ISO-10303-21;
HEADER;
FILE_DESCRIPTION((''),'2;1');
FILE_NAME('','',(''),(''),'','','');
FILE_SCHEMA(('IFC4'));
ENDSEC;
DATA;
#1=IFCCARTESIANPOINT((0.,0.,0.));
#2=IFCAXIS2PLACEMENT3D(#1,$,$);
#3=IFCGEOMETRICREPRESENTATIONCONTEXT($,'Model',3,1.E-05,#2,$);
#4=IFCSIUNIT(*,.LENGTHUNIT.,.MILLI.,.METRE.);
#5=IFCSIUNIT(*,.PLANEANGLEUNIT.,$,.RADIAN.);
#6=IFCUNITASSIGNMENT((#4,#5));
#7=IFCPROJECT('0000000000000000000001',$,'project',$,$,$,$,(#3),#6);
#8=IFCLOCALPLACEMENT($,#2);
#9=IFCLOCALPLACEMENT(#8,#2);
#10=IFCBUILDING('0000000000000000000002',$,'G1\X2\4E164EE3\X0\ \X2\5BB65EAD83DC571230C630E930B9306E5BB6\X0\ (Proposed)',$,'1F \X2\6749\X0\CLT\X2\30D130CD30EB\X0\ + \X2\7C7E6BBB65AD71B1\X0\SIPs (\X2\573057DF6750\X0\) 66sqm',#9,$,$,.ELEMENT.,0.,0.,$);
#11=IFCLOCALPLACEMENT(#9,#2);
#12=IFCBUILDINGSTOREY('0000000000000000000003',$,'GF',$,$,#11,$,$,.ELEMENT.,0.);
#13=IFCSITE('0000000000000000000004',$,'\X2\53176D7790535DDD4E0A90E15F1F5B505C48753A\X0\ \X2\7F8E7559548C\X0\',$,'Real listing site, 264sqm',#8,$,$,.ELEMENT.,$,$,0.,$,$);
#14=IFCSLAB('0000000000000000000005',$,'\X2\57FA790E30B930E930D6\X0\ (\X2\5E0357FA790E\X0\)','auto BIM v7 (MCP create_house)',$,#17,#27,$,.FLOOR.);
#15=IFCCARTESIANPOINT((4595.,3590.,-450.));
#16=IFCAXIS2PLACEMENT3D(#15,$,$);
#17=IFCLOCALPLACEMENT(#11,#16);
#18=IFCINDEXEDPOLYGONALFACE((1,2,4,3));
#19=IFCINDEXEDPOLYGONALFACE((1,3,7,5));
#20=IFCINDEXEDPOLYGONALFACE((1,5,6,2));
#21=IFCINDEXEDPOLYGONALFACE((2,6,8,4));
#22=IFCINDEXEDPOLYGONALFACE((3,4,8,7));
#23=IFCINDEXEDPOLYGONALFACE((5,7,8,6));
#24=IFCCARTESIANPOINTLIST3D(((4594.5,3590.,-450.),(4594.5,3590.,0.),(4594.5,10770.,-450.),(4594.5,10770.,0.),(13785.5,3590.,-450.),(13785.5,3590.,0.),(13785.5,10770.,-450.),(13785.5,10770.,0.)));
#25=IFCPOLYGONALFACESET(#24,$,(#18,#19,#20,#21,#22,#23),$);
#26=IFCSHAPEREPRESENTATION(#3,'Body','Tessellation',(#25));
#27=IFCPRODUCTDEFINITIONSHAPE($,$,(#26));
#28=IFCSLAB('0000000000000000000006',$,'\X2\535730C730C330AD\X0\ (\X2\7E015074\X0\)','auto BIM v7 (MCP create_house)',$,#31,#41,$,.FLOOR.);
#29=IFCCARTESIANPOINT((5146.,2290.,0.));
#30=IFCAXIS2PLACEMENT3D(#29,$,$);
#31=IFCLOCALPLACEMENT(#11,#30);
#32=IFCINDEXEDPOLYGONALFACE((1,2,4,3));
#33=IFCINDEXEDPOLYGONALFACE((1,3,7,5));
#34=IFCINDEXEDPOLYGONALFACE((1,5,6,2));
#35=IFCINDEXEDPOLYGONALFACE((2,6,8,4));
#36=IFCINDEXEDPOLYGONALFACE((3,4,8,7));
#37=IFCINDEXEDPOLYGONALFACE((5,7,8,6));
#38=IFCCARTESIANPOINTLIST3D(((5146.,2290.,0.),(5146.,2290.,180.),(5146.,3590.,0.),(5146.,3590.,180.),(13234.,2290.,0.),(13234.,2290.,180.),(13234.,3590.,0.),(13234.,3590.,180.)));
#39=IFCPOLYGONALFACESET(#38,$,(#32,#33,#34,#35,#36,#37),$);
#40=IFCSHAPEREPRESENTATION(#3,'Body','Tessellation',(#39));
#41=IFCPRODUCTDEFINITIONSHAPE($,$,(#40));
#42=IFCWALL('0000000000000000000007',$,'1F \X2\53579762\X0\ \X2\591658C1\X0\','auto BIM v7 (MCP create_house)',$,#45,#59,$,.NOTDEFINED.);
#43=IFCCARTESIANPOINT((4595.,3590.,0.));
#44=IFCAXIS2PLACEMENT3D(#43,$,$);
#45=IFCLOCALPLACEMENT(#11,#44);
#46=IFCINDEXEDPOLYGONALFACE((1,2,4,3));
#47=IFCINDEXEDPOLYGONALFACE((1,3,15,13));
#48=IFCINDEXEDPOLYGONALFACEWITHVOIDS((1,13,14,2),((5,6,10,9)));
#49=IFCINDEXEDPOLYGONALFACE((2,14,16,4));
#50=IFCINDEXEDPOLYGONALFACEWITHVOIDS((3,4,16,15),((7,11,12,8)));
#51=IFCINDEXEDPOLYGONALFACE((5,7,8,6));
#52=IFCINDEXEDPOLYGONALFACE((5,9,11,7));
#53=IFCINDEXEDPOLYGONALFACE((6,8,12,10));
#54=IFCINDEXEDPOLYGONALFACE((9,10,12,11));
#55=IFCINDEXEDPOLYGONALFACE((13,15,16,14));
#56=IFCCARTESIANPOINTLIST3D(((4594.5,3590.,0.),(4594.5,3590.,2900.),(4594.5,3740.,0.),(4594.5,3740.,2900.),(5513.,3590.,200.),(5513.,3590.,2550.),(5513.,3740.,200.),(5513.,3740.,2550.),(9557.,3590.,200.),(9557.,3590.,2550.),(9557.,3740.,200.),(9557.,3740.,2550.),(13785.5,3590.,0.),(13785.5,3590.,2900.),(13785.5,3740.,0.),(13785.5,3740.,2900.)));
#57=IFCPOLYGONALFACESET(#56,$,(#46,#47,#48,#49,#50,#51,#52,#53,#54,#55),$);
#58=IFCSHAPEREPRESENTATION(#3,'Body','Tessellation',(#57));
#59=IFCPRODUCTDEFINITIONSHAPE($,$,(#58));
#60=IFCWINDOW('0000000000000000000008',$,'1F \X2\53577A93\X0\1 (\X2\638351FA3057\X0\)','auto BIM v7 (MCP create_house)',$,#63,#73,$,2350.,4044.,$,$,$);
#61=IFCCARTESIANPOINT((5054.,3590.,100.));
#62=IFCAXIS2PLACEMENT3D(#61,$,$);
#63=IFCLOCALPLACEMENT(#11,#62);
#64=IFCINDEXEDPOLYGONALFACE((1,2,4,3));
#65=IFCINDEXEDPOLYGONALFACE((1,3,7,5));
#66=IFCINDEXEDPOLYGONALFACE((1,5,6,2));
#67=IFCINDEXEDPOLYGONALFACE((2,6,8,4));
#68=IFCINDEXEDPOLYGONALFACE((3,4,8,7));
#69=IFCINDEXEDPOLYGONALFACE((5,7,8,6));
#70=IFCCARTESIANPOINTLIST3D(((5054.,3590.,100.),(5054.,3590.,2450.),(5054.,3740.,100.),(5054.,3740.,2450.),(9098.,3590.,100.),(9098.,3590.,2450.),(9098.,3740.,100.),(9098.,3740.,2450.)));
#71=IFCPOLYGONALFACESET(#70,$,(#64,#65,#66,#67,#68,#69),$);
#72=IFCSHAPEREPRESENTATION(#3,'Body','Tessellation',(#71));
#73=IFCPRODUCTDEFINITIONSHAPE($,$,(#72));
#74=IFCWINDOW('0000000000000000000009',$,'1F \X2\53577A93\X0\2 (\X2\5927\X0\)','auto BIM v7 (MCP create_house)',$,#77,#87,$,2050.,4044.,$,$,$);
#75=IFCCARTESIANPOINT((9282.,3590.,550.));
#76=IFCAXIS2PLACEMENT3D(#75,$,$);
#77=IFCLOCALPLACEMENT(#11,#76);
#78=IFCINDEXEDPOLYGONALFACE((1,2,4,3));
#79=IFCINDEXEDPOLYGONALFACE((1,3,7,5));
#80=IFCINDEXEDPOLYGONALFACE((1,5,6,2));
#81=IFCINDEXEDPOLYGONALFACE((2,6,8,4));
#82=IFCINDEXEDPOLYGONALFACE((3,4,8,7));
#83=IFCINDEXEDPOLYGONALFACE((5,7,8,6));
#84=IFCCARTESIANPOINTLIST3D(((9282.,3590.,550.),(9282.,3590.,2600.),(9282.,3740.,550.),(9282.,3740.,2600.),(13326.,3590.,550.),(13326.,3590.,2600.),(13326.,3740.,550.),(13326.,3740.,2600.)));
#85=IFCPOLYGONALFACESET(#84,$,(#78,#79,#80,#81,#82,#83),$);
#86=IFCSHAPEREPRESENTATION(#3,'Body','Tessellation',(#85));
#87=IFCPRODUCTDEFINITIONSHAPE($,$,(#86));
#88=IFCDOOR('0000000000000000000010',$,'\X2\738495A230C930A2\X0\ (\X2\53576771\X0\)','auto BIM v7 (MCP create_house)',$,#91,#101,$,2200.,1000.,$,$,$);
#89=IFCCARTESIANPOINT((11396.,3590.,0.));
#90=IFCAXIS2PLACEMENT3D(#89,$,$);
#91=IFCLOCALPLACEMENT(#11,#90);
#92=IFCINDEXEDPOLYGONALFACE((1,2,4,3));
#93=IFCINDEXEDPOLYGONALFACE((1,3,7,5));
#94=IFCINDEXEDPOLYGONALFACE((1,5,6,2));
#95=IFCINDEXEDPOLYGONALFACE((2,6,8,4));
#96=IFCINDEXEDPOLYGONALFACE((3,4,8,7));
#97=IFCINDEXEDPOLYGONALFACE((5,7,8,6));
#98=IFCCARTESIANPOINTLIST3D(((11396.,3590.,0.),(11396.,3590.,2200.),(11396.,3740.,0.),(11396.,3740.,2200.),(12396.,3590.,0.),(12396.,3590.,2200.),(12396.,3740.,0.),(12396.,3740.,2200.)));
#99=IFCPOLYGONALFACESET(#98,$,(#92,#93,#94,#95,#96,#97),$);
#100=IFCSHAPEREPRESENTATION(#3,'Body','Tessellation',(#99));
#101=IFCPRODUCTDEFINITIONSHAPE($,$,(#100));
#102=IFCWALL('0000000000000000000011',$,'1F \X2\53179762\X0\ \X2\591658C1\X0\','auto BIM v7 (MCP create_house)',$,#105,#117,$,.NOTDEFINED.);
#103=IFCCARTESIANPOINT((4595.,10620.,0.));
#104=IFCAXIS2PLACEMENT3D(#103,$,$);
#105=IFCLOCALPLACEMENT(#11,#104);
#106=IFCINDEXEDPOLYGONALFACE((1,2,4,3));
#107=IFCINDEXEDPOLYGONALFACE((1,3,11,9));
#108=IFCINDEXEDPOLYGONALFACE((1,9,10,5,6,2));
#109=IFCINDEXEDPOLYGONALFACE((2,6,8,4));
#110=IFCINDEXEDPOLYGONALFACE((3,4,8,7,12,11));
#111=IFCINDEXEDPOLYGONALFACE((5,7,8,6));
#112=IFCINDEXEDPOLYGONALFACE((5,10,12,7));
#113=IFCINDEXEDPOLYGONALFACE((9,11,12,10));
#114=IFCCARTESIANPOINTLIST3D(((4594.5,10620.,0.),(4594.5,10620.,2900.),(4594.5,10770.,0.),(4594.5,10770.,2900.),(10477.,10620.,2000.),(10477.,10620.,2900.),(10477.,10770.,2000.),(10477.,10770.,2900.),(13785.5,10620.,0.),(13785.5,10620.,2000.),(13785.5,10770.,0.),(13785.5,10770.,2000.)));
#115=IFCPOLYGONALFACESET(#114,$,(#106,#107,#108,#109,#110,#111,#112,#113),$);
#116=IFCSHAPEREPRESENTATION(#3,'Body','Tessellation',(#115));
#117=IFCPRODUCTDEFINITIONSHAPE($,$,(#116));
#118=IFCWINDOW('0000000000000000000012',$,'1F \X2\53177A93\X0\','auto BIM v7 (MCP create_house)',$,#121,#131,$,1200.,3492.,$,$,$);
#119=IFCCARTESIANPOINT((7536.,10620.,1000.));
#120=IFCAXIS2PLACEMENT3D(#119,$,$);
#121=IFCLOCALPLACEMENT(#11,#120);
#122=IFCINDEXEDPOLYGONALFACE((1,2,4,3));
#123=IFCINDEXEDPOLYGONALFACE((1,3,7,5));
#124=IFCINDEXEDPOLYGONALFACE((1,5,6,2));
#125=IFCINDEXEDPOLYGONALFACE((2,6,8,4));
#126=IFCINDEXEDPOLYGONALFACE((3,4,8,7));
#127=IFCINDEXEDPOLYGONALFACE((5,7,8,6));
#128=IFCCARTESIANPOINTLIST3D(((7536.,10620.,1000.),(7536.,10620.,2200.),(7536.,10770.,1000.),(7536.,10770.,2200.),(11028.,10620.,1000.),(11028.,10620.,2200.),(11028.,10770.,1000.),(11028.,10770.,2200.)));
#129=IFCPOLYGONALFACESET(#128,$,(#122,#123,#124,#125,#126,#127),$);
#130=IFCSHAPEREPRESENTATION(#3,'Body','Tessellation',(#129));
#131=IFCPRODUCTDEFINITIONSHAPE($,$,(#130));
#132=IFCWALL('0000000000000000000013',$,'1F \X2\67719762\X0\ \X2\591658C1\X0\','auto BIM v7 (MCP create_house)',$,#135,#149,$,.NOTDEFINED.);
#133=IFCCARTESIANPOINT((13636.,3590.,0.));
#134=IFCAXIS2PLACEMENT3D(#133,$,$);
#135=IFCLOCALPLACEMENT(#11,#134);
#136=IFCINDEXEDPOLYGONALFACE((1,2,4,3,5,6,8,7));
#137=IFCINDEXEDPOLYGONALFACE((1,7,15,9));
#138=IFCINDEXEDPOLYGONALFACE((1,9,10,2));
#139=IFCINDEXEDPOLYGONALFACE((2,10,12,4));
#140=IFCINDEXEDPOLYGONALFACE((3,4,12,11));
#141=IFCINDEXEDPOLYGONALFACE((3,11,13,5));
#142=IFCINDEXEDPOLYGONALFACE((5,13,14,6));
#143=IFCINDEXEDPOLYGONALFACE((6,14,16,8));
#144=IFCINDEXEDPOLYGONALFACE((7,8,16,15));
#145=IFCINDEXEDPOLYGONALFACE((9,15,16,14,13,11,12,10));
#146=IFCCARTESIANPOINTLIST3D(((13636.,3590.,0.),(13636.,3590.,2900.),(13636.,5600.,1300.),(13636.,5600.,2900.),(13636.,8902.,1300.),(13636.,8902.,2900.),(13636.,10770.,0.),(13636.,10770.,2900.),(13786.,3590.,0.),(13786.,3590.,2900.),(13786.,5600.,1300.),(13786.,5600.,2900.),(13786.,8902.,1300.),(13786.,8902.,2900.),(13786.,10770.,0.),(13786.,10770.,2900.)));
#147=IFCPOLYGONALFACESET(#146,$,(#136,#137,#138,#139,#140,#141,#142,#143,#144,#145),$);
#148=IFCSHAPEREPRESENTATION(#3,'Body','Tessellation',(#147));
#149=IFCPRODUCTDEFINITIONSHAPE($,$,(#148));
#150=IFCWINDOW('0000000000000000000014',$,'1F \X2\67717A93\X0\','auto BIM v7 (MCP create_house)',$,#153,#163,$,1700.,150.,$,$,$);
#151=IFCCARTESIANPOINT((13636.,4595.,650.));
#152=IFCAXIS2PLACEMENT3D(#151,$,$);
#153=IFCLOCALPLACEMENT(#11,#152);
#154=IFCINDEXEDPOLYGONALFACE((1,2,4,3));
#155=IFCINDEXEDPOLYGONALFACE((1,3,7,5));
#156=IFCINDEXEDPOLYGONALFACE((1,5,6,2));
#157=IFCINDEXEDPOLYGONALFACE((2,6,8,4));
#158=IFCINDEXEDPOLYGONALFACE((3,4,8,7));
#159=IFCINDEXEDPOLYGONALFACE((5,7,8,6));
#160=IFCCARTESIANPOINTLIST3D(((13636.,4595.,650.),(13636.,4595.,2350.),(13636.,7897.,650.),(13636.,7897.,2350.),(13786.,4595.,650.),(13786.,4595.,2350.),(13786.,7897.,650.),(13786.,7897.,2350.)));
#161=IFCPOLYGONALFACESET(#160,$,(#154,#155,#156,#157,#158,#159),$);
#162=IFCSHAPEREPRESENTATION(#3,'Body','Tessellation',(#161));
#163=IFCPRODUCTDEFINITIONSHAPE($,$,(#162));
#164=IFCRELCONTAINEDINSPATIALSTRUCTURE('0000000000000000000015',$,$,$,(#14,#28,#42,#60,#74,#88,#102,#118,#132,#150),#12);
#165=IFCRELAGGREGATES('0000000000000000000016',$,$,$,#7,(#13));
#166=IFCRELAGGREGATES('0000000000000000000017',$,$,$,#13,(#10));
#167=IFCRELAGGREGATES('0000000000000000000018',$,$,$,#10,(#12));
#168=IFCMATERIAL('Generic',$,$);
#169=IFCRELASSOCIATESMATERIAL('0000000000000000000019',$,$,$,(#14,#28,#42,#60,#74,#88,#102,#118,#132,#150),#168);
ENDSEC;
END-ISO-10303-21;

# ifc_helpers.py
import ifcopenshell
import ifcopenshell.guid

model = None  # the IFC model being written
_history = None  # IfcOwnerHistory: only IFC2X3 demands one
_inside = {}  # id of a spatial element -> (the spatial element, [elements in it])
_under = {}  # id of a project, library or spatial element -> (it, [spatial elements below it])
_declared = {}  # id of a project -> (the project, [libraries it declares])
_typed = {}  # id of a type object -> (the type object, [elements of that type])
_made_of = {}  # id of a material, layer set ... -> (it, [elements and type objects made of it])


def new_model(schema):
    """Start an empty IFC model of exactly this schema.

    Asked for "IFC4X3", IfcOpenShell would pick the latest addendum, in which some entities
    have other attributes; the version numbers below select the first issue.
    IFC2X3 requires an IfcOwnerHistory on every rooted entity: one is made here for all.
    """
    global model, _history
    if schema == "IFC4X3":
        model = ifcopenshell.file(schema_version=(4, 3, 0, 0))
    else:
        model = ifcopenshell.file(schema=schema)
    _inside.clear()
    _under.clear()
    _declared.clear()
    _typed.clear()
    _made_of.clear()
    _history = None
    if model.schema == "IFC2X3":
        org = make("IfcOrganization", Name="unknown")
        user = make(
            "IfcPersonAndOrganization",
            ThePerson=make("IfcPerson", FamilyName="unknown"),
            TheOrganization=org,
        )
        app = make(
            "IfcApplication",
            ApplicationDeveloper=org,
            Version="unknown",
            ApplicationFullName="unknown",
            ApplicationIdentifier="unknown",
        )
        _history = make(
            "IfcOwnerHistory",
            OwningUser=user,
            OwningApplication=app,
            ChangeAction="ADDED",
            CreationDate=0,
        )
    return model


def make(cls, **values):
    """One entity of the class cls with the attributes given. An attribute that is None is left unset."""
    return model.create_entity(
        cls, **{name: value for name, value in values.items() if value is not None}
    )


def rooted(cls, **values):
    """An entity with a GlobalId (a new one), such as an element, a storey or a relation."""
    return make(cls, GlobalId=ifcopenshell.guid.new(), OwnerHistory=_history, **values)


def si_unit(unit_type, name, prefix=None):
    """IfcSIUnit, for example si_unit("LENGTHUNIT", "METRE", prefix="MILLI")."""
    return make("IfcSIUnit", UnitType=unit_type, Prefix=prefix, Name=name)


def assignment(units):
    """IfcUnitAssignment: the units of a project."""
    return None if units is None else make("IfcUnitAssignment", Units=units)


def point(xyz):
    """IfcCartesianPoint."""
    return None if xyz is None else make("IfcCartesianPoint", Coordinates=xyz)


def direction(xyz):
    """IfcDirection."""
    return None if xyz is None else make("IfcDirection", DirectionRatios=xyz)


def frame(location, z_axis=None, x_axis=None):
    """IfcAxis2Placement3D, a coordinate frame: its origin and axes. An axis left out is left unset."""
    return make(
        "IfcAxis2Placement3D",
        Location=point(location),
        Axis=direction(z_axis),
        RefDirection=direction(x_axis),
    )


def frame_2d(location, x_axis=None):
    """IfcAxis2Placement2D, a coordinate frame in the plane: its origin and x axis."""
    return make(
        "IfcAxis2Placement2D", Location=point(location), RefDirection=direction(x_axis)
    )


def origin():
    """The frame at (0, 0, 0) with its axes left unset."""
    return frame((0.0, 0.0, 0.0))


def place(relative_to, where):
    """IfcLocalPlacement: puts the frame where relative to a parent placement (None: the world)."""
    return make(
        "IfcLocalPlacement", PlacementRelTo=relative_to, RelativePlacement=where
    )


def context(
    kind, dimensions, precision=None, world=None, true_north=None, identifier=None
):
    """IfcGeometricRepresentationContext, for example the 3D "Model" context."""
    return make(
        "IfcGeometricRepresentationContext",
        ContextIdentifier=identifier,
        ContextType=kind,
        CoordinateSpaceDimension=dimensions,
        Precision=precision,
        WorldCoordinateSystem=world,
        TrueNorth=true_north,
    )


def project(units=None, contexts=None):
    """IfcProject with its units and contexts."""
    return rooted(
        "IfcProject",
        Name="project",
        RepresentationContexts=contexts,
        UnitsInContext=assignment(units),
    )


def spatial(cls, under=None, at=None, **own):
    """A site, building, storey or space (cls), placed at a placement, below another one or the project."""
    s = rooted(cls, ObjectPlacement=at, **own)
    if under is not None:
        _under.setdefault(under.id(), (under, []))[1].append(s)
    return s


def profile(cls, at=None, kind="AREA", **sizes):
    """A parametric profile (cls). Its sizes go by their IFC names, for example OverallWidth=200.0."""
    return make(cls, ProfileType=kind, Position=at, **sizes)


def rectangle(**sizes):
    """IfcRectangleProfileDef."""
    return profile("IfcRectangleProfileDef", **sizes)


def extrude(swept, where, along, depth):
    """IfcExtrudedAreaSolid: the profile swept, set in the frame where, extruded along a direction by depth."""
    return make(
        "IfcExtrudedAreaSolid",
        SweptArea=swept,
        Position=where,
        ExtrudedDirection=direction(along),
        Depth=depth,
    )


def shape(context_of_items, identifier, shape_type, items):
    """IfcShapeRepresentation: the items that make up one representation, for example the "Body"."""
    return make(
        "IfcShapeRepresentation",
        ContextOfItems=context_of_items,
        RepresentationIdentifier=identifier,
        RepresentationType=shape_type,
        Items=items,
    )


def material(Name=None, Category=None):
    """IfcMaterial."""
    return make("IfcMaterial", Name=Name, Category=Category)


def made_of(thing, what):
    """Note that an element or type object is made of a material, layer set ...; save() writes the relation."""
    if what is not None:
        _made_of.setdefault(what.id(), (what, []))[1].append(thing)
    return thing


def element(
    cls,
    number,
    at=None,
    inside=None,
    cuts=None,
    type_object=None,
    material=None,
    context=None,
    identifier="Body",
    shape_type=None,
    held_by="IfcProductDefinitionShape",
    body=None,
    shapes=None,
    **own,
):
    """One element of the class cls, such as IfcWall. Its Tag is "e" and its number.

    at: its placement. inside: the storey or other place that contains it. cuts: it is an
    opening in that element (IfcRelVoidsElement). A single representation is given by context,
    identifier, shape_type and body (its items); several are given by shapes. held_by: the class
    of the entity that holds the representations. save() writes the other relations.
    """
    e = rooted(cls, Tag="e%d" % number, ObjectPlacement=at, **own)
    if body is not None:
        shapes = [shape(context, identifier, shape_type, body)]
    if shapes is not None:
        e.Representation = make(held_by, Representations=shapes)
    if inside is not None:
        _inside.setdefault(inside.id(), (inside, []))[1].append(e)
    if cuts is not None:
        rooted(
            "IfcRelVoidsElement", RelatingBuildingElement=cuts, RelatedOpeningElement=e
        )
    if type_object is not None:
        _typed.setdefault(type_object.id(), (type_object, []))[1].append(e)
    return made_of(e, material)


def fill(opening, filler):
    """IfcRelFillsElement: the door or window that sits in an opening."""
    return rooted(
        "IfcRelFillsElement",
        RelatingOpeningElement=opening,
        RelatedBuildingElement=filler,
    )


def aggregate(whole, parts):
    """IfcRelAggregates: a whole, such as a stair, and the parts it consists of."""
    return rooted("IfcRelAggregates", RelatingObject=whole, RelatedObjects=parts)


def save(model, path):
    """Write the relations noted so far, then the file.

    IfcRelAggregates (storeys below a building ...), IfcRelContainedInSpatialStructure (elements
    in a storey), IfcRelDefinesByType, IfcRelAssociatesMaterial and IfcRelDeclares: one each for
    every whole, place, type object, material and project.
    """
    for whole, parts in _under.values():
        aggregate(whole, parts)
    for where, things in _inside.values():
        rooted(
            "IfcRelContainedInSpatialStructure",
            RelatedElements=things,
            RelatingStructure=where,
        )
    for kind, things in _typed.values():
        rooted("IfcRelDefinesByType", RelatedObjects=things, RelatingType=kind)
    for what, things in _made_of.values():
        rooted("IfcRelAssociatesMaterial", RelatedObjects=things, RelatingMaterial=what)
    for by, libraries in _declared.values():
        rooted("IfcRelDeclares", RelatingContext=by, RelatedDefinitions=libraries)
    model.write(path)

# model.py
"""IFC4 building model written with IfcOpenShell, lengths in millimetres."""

from ifc_helpers import new_model, si_unit, frame, frame_2d, origin, place, context, project, spatial, rectangle, extrude, material, element, fill, save


model = new_model("IFC4")

# Units and contexts
model_context = context("Model", 3, precision=1e-05, world=origin())
ifc_project = project(units=[si_unit("LENGTHUNIT", "METRE", prefix="MILLI"), si_unit("PLANEANGLEUNIT", "RADIAN")], contexts=[model_context])

# Site, building, storey
site_placement = place(None, origin())
site = spatial("IfcSite", under=ifc_project, at=site_placement, Name="北海道川上郡弟子屈町 美留和", ObjectType="Real listing site, 264sqm", CompositionType="ELEMENT", RefElevation=0.0)
building_placement = place(site_placement, origin())
building = spatial("IfcBuilding", under=site, at=building_placement, Name="G1世代 家庭菜園テラスの家 (Proposed)", ObjectType="1F 杉CLTパネル + 籾殻断熱SIPs (地域材) 66sqm", CompositionType="ELEMENT", ElevationOfRefHeight=0.0, ElevationOfTerrain=0.0)
storey_placement = place(building_placement, origin())
storey = spatial("IfcBuildingStorey", under=building, at=storey_placement, Name="GF", CompositionType="ELEMENT", Elevation=0.0)

# Slabs
ifc_material = material(Name="Generic")
slab_1_placement = place(storey_placement, frame((4595.0, 3590.0, -450.0)))
element("IfcSlab", 1, at=slab_1_placement, inside=storey, material=ifc_material, Name="基礎スラブ (布基礎)", Description="auto BIM v7 (MCP create_house)", PredefinedType="FLOOR", context=model_context, shape_type="SweptSolid", body=[
    extrude(rectangle(XDim=9191.0, YDim=7180.0, at=frame_2d((4595.0, 3590.0))), frame((4595.0, 3590.0, -450.0)), (0.0, 0.0, 1.0), 450.0),
])
slab_2_placement = place(storey_placement, frame((5146.0, 2290.0, 0.0)))
element("IfcSlab", 2, at=slab_2_placement, inside=storey, material=ifc_material, Name="南デッキ (縁側)", Description="auto BIM v7 (MCP create_house)", PredefinedType="FLOOR", context=model_context, shape_type="SweptSolid", body=[
    extrude(rectangle(XDim=8088.0, YDim=1300.0, at=frame_2d((4044.0, 650.0))), frame((5146.0, 2290.0, 0.0)), (0.0, 0.0, 1.0), 180.0),
])

# Wall, openings, windows, door
wall_1_placement = place(storey_placement, frame((4595.0, 3590.0, 0.0)))
wall_1 = element("IfcWall", 3, at=wall_1_placement, inside=storey, material=ifc_material, Name="1F 南面 外壁", Description="auto BIM v7 (MCP create_house)", PredefinedType="NOTDEFINED", context=model_context, shape_type="SweptSolid", body=[
    extrude(rectangle(XDim=9191.0, YDim=150.0, at=frame_2d((4595.0, 75.0))), frame((4595.0, 3590.0, 0.0)), (0.0, 0.0, 1.0), 2900.0),
])
opening_1_placement = place(storey_placement, frame((5054.0, 3590.0, 100.0)))
opening_1 = element("IfcOpeningElement", 4, at=opening_1_placement, cuts=wall_1, PredefinedType="NOTDEFINED", context=model_context, shape_type="SweptSolid", body=[
    extrude(rectangle(XDim=4044.0, YDim=150.0, at=frame_2d((2022.0, 75.0))), frame((5054.0, 3590.0, 100.0)), (0.0, 0.0, 1.0), 2350.0),
])
opening_2_placement = place(storey_placement, frame((9282.0, 3590.0, 550.0)))
opening_2 = element("IfcOpeningElement", 5, at=opening_2_placement, cuts=wall_1, PredefinedType="NOTDEFINED", context=model_context, shape_type="SweptSolid", body=[
    extrude(rectangle(XDim=4044.0, YDim=150.0, at=frame_2d((2022.0, 75.0))), frame((9282.0, 3590.0, 550.0)), (0.0, 0.0, 1.0), 2050.0),
])
opening_3_placement = place(storey_placement, frame((11396.0, 3590.0, 0.0)))
opening_3 = element("IfcOpeningElement", 6, at=opening_3_placement, cuts=wall_1, PredefinedType="NOTDEFINED", context=model_context, shape_type="SweptSolid", body=[
    extrude(rectangle(XDim=1000.0, YDim=150.0, at=frame_2d((500.0, 75.0))), frame((11396.0, 3590.0, 0.0)), (0.0, 0.0, 1.0), 2200.0),
])
window_1_placement = place(storey_placement, frame((5054.0, 3590.0, 100.0)))
window_1 = element("IfcWindow", 7, at=window_1_placement, inside=storey, material=ifc_material, Name="1F 南窓1 (掃出し)", Description="auto BIM v7 (MCP create_house)", OverallHeight=2350.0, OverallWidth=4044.0, context=model_context, shape_type="SweptSolid", body=[
    extrude(rectangle(XDim=4044.0, YDim=150.0, at=frame_2d((2022.0, 75.0))), frame((5054.0, 3590.0, 100.0)), (0.0, 0.0, 1.0), 2350.0),
])
fill(opening_1, window_1)
window_2_placement = place(storey_placement, frame((9282.0, 3590.0, 550.0)))
window_2 = element("IfcWindow", 8, at=window_2_placement, inside=storey, material=ifc_material, Name="1F 南窓2 (大)", Description="auto BIM v7 (MCP create_house)", OverallHeight=2050.0, OverallWidth=4044.0, context=model_context, shape_type="SweptSolid", body=[
    extrude(rectangle(XDim=4044.0, YDim=150.0, at=frame_2d((2022.0, 75.0))), frame((9282.0, 3590.0, 550.0)), (0.0, 0.0, 1.0), 2050.0),
])
fill(opening_2, window_2)
door_placement = place(storey_placement, frame((11396.0, 3590.0, 0.0)))
door = element("IfcDoor", 9, at=door_placement, inside=storey, material=ifc_material, Name="玄関ドア (南東)", Description="auto BIM v7 (MCP create_house)", OverallHeight=2200.0, OverallWidth=1000.0, context=model_context, shape_type="SweptSolid", body=[
    extrude(rectangle(XDim=1000.0, YDim=150.0, at=frame_2d((500.0, 75.0))), frame((11396.0, 3590.0, 0.0)), (0.0, 0.0, 1.0), 2200.0),
])
fill(opening_3, door)

# Walls, openings, windows
wall_2_placement = place(storey_placement, frame((4595.0, 10620.0, 0.0)))
wall_2 = element("IfcWall", 10, at=wall_2_placement, inside=storey, material=ifc_material, Name="1F 北面 外壁", Description="auto BIM v7 (MCP create_house)", PredefinedType="NOTDEFINED", context=model_context, shape_type="SweptSolid", body=[
    extrude(rectangle(XDim=9191.0, YDim=150.0, at=frame_2d((4595.0, 75.0))), frame((4595.0, 10620.0, 0.0)), (0.0, 0.0, 1.0), 2900.0),
])
opening_4_placement = place(storey_placement, frame((7536.0, 10620.0, 1000.0)))
opening_4 = element("IfcOpeningElement", 11, at=opening_4_placement, cuts=wall_2, PredefinedType="NOTDEFINED", context=model_context, shape_type="SweptSolid", body=[
    extrude(rectangle(XDim=3492.0, YDim=150.0, at=frame_2d((1746.0, 75.0))), frame((7536.0, 10620.0, 1000.0)), (0.0, 0.0, 1.0), 1200.0),
])
window_3_placement = place(storey_placement, frame((7536.0, 10620.0, 1000.0)))
window_3 = element("IfcWindow", 12, at=window_3_placement, inside=storey, material=ifc_material, Name="1F 北窓", Description="auto BIM v7 (MCP create_house)", OverallHeight=1200.0, OverallWidth=3492.0, context=model_context, shape_type="SweptSolid", body=[
    extrude(rectangle(XDim=3492.0, YDim=150.0, at=frame_2d((1746.0, 75.0))), frame((7536.0, 10620.0, 1000.0)), (0.0, 0.0, 1.0), 1200.0),
])
fill(opening_4, window_3)
wall_3_placement = place(storey_placement, frame((13636.0, 3590.0, 0.0)))
wall_3 = element("IfcWall", 13, at=wall_3_placement, inside=storey, material=ifc_material, Name="1F 東面 外壁", Description="auto BIM v7 (MCP create_house)", PredefinedType="NOTDEFINED", context=model_context, shape_type="SweptSolid", body=[
    extrude(rectangle(XDim=150.0, YDim=7180.0, at=frame_2d((75.0, 3590.0))), frame((13636.0, 3590.0, 0.0)), (0.0, 0.0, 1.0), 2900.0),
])
opening_5_placement = place(storey_placement, frame((13636.0, 4595.0, 650.0)))
opening_5 = element("IfcOpeningElement", 14, at=opening_5_placement, cuts=wall_3, PredefinedType="NOTDEFINED", context=model_context, shape_type="SweptSolid", body=[
    extrude(rectangle(XDim=150.0, YDim=3302.0, at=frame_2d((75.0, 1651.0))), frame((13636.0, 4595.0, 650.0)), (0.0, 0.0, 1.0), 1700.0),
])
window_4_placement = place(storey_placement, frame((13636.0, 4595.0, 650.0)))
window_4 = element("IfcWindow", 15, at=window_4_placement, inside=storey, material=ifc_material, Name="1F 東窓", Description="auto BIM v7 (MCP create_house)", OverallHeight=1700.0, OverallWidth=150.0, context=model_context, shape_type="SweptSolid", body=[
    extrude(rectangle(XDim=150.0, YDim=3302.0, at=frame_2d((75.0, 1651.0))), frame((13636.0, 4595.0, 650.0)), (0.0, 0.0, 1.0), 1700.0),
])
fill(opening_5, window_4)

save(model, "model.ifc")
